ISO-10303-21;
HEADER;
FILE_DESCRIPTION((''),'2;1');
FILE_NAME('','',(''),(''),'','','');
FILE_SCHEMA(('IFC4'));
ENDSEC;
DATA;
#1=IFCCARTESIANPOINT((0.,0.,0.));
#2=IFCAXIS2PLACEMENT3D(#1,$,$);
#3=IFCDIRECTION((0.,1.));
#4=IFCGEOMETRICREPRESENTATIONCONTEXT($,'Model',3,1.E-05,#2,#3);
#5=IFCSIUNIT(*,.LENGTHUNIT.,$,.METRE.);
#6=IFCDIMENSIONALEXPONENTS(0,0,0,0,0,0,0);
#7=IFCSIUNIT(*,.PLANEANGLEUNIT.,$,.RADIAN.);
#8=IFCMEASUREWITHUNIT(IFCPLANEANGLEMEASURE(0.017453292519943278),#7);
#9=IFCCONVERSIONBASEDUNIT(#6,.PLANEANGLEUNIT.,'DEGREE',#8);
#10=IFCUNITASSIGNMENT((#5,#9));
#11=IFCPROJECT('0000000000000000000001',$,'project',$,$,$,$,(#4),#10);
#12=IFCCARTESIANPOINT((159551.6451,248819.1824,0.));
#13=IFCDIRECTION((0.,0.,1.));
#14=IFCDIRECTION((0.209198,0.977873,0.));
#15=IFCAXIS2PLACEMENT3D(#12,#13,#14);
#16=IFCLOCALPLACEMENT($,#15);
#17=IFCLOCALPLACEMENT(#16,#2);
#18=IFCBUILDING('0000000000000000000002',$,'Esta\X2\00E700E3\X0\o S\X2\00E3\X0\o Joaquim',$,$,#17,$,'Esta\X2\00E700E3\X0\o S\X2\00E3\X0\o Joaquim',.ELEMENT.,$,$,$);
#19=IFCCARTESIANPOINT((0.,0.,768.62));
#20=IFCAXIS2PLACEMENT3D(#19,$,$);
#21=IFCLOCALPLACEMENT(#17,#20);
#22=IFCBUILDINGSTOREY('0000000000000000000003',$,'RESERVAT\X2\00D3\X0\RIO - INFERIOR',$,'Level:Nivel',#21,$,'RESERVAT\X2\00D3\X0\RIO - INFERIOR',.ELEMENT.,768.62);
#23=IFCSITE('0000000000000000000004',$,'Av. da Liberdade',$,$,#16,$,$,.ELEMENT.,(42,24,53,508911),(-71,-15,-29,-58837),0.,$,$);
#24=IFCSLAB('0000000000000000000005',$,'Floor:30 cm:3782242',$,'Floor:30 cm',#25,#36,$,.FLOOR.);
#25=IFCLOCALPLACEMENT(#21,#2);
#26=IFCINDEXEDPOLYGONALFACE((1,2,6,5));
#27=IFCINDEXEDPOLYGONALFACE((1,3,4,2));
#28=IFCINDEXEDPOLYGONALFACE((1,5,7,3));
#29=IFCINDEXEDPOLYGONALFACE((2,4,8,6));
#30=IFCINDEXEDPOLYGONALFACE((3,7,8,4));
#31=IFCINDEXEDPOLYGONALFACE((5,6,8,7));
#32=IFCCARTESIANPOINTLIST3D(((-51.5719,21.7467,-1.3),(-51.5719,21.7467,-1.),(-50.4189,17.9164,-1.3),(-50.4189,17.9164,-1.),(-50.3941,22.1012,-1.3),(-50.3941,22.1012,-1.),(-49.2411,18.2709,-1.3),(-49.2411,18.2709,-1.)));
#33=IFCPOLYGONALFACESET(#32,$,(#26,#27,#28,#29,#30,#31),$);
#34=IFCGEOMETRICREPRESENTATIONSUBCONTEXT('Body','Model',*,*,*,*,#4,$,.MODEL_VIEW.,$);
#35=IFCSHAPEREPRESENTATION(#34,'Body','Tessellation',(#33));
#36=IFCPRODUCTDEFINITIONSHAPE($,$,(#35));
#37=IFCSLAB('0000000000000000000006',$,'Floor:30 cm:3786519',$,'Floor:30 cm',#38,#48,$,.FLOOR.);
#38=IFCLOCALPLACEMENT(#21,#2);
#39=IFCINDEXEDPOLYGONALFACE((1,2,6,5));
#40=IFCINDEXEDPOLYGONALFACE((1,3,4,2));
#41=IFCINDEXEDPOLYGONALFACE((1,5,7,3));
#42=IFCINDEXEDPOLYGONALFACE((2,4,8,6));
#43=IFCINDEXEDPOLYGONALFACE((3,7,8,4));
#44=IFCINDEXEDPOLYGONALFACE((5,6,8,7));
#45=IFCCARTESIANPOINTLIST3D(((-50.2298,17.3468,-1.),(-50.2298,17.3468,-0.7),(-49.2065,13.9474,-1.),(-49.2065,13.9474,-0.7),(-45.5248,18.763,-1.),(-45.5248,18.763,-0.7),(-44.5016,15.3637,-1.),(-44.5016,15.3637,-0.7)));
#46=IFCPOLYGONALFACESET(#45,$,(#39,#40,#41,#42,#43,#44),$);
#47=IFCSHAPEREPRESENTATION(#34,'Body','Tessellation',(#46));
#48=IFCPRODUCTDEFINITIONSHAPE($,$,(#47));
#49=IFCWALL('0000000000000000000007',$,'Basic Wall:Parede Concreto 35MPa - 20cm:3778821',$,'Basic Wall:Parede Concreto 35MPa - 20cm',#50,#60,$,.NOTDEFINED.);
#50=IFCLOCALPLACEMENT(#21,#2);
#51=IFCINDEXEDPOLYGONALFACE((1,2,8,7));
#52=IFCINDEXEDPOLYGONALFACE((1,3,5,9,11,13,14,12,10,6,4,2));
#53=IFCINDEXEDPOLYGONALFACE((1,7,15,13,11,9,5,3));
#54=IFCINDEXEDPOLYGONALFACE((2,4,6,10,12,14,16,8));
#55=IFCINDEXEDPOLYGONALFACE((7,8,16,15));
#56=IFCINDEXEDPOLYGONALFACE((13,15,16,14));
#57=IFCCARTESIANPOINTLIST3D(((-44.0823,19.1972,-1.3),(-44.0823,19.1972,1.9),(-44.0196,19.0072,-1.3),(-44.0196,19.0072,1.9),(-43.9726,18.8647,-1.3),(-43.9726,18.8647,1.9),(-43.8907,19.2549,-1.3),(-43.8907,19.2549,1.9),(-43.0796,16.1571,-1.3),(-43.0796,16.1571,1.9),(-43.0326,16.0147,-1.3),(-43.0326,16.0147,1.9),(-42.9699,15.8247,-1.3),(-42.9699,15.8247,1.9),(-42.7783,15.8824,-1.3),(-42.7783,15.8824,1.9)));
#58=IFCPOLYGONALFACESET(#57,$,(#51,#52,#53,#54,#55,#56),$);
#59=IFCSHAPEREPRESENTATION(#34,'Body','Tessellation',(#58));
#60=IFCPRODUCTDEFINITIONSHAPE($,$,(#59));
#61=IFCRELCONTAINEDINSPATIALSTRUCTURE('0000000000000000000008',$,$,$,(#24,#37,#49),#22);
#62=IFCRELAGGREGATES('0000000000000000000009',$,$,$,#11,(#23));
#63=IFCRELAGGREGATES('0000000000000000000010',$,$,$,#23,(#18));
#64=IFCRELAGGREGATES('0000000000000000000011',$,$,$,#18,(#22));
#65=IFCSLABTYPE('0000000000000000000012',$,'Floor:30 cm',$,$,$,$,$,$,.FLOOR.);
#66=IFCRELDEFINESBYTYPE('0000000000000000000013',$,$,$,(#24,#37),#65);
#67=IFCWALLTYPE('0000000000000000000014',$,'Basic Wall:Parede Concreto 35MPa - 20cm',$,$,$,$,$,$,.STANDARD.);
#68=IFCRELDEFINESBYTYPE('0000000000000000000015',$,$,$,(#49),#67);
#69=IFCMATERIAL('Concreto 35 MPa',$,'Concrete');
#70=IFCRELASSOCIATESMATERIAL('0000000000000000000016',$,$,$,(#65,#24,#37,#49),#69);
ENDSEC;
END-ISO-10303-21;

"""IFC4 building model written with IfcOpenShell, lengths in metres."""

from ifc_helpers import new_model, entity, si_unit, converted_unit, direction, frame, origin, place, context, subcontext, project, spatial, indexed_curve, outline, extrude, material, type_object, element, save


model = new_model("IFC4")

# Units and contexts
model_context = context("Model", 3, precision=1e-05, world=origin(), true_north=direction((0.0, 1.0)))
body_context = subcontext(model_context, "Body", "Model", "MODEL_VIEW")
ifc_project = project(units=[si_unit("LENGTHUNIT", "METRE"), converted_unit("PLANEANGLEUNIT", "DEGREE", entity("IfcPlaneAngleMeasure", 0.017453292519943278), si_unit("PLANEANGLEUNIT", "RADIAN"), dimensions=[0, 0, 0, 0, 0, 0, 0])], contexts=[model_context])

# Site, building, storey
site_placement = place(None, frame((159551.6451, 248819.1824, 0.0), z_axis=(0.0, 0.0, 1.0), x_axis=(0.209198, 0.977873, 0.0)))
site = spatial("IfcSite", under=ifc_project, at=site_placement, Name="Av. da Liberdade", CompositionType="ELEMENT", RefLatitude=(42, 24, 53, 508911), RefLongitude=(-71, -15, -29, -58837), RefElevation=0.0)
building_placement = place(site_placement, origin())
building = spatial("IfcBuilding", under=site, at=building_placement, Name="Estação São Joaquim", LongName="Estação São Joaquim", CompositionType="ELEMENT")
storey_placement = place(building_placement, frame((0.0, 0.0, 768.62)))
storey = spatial("IfcBuildingStorey", under=building, at=storey_placement, Name="RESERVATÓRIO - INFERIOR", ObjectType="Level:Nivel", LongName="RESERVATÓRIO - INFERIOR", CompositionType="ELEMENT", Elevation=768.62)

# Slabs
ifc_material = material(Name="Concreto 35 MPa", Category="Concrete")
slab_type = type_object("IfcSlabType", Name="Floor:30 cm", PredefinedType="FLOOR", material=ifc_material)
slab_1_placement = place(storey_placement, origin())
element("IfcSlab", 1, at=slab_1_placement, inside=storey, type_object=slab_type, material=ifc_material, Name="Floor:30 cm:3782242", ObjectType="Floor:30 cm", PredefinedType="FLOOR", context=body_context, shape_type="SweptSolid", body=[
    extrude(outline(indexed_curve([(-2.0, -0.615), (2.0, -0.615), (2.0, 0.615), (-2.0, 0.615), (-2.0, -0.615)], self_intersect=False)), frame((-50.4065, 20.0088, -1.0), z_axis=(0.0, 0.0, -1.0), x_axis=(0.288234, -0.95756, 0.0)), (0.0, 0.0, 1.0), 0.3),
])
slab_2_placement = place(storey_placement, origin())
element("IfcSlab", 2, at=slab_2_placement, inside=storey, type_object=slab_type, material=ifc_material, Name="Floor:30 cm:3786519", ObjectType="Floor:30 cm", PredefinedType="FLOOR", context=body_context, shape_type="SweptSolid", body=[
    extrude(outline(indexed_curve([(-1.775, -2.4568), (1.775, -2.4568), (1.775, 2.4568), (-1.775, 2.4568), (-1.775, -2.4568)], self_intersect=False)), frame((-47.3657, 16.3552, -0.7), z_axis=(0.0, 0.0, -1.0), x_axis=(0.288234, -0.95756, 0.0)), (0.0, 0.0, 1.0), 0.3),
])

# Wall
wall_type = type_object("IfcWallType", Name="Basic Wall:Parede Concreto 35MPa - 20cm", PredefinedType="STANDARD")
wall_placement = place(storey_placement, frame((-42.8733, 15.851, -1.3), z_axis=(0.0, 0.0, 1.0), x_axis=(-0.313241, 0.949674, 0.0)))
element("IfcWall", 3, at=wall_placement, inside=storey, type_object=wall_type, material=ifc_material, Name="Basic Wall:Parede Concreto 35MPa - 20cm:3778821", ObjectType="Basic Wall:Parede Concreto 35MPa - 20cm", PredefinedType="NOTDEFINED", context=body_context, shape_type="SweptSolid", body=[
    extrude(outline(indexed_curve([(3.5512, -0.1), (3.5565, 0.1), (3.3564, 0.1), (3.2064, 0.1), (0.3553, 0.1), (0.2053, 0.1), (0.0052, 0.1), (0.0, -0.1), (3.5512, -0.1)], self_intersect=False)), origin(), (0.0, 0.0, 1.0), 3.2),
])

save(model, "model.ifc")
